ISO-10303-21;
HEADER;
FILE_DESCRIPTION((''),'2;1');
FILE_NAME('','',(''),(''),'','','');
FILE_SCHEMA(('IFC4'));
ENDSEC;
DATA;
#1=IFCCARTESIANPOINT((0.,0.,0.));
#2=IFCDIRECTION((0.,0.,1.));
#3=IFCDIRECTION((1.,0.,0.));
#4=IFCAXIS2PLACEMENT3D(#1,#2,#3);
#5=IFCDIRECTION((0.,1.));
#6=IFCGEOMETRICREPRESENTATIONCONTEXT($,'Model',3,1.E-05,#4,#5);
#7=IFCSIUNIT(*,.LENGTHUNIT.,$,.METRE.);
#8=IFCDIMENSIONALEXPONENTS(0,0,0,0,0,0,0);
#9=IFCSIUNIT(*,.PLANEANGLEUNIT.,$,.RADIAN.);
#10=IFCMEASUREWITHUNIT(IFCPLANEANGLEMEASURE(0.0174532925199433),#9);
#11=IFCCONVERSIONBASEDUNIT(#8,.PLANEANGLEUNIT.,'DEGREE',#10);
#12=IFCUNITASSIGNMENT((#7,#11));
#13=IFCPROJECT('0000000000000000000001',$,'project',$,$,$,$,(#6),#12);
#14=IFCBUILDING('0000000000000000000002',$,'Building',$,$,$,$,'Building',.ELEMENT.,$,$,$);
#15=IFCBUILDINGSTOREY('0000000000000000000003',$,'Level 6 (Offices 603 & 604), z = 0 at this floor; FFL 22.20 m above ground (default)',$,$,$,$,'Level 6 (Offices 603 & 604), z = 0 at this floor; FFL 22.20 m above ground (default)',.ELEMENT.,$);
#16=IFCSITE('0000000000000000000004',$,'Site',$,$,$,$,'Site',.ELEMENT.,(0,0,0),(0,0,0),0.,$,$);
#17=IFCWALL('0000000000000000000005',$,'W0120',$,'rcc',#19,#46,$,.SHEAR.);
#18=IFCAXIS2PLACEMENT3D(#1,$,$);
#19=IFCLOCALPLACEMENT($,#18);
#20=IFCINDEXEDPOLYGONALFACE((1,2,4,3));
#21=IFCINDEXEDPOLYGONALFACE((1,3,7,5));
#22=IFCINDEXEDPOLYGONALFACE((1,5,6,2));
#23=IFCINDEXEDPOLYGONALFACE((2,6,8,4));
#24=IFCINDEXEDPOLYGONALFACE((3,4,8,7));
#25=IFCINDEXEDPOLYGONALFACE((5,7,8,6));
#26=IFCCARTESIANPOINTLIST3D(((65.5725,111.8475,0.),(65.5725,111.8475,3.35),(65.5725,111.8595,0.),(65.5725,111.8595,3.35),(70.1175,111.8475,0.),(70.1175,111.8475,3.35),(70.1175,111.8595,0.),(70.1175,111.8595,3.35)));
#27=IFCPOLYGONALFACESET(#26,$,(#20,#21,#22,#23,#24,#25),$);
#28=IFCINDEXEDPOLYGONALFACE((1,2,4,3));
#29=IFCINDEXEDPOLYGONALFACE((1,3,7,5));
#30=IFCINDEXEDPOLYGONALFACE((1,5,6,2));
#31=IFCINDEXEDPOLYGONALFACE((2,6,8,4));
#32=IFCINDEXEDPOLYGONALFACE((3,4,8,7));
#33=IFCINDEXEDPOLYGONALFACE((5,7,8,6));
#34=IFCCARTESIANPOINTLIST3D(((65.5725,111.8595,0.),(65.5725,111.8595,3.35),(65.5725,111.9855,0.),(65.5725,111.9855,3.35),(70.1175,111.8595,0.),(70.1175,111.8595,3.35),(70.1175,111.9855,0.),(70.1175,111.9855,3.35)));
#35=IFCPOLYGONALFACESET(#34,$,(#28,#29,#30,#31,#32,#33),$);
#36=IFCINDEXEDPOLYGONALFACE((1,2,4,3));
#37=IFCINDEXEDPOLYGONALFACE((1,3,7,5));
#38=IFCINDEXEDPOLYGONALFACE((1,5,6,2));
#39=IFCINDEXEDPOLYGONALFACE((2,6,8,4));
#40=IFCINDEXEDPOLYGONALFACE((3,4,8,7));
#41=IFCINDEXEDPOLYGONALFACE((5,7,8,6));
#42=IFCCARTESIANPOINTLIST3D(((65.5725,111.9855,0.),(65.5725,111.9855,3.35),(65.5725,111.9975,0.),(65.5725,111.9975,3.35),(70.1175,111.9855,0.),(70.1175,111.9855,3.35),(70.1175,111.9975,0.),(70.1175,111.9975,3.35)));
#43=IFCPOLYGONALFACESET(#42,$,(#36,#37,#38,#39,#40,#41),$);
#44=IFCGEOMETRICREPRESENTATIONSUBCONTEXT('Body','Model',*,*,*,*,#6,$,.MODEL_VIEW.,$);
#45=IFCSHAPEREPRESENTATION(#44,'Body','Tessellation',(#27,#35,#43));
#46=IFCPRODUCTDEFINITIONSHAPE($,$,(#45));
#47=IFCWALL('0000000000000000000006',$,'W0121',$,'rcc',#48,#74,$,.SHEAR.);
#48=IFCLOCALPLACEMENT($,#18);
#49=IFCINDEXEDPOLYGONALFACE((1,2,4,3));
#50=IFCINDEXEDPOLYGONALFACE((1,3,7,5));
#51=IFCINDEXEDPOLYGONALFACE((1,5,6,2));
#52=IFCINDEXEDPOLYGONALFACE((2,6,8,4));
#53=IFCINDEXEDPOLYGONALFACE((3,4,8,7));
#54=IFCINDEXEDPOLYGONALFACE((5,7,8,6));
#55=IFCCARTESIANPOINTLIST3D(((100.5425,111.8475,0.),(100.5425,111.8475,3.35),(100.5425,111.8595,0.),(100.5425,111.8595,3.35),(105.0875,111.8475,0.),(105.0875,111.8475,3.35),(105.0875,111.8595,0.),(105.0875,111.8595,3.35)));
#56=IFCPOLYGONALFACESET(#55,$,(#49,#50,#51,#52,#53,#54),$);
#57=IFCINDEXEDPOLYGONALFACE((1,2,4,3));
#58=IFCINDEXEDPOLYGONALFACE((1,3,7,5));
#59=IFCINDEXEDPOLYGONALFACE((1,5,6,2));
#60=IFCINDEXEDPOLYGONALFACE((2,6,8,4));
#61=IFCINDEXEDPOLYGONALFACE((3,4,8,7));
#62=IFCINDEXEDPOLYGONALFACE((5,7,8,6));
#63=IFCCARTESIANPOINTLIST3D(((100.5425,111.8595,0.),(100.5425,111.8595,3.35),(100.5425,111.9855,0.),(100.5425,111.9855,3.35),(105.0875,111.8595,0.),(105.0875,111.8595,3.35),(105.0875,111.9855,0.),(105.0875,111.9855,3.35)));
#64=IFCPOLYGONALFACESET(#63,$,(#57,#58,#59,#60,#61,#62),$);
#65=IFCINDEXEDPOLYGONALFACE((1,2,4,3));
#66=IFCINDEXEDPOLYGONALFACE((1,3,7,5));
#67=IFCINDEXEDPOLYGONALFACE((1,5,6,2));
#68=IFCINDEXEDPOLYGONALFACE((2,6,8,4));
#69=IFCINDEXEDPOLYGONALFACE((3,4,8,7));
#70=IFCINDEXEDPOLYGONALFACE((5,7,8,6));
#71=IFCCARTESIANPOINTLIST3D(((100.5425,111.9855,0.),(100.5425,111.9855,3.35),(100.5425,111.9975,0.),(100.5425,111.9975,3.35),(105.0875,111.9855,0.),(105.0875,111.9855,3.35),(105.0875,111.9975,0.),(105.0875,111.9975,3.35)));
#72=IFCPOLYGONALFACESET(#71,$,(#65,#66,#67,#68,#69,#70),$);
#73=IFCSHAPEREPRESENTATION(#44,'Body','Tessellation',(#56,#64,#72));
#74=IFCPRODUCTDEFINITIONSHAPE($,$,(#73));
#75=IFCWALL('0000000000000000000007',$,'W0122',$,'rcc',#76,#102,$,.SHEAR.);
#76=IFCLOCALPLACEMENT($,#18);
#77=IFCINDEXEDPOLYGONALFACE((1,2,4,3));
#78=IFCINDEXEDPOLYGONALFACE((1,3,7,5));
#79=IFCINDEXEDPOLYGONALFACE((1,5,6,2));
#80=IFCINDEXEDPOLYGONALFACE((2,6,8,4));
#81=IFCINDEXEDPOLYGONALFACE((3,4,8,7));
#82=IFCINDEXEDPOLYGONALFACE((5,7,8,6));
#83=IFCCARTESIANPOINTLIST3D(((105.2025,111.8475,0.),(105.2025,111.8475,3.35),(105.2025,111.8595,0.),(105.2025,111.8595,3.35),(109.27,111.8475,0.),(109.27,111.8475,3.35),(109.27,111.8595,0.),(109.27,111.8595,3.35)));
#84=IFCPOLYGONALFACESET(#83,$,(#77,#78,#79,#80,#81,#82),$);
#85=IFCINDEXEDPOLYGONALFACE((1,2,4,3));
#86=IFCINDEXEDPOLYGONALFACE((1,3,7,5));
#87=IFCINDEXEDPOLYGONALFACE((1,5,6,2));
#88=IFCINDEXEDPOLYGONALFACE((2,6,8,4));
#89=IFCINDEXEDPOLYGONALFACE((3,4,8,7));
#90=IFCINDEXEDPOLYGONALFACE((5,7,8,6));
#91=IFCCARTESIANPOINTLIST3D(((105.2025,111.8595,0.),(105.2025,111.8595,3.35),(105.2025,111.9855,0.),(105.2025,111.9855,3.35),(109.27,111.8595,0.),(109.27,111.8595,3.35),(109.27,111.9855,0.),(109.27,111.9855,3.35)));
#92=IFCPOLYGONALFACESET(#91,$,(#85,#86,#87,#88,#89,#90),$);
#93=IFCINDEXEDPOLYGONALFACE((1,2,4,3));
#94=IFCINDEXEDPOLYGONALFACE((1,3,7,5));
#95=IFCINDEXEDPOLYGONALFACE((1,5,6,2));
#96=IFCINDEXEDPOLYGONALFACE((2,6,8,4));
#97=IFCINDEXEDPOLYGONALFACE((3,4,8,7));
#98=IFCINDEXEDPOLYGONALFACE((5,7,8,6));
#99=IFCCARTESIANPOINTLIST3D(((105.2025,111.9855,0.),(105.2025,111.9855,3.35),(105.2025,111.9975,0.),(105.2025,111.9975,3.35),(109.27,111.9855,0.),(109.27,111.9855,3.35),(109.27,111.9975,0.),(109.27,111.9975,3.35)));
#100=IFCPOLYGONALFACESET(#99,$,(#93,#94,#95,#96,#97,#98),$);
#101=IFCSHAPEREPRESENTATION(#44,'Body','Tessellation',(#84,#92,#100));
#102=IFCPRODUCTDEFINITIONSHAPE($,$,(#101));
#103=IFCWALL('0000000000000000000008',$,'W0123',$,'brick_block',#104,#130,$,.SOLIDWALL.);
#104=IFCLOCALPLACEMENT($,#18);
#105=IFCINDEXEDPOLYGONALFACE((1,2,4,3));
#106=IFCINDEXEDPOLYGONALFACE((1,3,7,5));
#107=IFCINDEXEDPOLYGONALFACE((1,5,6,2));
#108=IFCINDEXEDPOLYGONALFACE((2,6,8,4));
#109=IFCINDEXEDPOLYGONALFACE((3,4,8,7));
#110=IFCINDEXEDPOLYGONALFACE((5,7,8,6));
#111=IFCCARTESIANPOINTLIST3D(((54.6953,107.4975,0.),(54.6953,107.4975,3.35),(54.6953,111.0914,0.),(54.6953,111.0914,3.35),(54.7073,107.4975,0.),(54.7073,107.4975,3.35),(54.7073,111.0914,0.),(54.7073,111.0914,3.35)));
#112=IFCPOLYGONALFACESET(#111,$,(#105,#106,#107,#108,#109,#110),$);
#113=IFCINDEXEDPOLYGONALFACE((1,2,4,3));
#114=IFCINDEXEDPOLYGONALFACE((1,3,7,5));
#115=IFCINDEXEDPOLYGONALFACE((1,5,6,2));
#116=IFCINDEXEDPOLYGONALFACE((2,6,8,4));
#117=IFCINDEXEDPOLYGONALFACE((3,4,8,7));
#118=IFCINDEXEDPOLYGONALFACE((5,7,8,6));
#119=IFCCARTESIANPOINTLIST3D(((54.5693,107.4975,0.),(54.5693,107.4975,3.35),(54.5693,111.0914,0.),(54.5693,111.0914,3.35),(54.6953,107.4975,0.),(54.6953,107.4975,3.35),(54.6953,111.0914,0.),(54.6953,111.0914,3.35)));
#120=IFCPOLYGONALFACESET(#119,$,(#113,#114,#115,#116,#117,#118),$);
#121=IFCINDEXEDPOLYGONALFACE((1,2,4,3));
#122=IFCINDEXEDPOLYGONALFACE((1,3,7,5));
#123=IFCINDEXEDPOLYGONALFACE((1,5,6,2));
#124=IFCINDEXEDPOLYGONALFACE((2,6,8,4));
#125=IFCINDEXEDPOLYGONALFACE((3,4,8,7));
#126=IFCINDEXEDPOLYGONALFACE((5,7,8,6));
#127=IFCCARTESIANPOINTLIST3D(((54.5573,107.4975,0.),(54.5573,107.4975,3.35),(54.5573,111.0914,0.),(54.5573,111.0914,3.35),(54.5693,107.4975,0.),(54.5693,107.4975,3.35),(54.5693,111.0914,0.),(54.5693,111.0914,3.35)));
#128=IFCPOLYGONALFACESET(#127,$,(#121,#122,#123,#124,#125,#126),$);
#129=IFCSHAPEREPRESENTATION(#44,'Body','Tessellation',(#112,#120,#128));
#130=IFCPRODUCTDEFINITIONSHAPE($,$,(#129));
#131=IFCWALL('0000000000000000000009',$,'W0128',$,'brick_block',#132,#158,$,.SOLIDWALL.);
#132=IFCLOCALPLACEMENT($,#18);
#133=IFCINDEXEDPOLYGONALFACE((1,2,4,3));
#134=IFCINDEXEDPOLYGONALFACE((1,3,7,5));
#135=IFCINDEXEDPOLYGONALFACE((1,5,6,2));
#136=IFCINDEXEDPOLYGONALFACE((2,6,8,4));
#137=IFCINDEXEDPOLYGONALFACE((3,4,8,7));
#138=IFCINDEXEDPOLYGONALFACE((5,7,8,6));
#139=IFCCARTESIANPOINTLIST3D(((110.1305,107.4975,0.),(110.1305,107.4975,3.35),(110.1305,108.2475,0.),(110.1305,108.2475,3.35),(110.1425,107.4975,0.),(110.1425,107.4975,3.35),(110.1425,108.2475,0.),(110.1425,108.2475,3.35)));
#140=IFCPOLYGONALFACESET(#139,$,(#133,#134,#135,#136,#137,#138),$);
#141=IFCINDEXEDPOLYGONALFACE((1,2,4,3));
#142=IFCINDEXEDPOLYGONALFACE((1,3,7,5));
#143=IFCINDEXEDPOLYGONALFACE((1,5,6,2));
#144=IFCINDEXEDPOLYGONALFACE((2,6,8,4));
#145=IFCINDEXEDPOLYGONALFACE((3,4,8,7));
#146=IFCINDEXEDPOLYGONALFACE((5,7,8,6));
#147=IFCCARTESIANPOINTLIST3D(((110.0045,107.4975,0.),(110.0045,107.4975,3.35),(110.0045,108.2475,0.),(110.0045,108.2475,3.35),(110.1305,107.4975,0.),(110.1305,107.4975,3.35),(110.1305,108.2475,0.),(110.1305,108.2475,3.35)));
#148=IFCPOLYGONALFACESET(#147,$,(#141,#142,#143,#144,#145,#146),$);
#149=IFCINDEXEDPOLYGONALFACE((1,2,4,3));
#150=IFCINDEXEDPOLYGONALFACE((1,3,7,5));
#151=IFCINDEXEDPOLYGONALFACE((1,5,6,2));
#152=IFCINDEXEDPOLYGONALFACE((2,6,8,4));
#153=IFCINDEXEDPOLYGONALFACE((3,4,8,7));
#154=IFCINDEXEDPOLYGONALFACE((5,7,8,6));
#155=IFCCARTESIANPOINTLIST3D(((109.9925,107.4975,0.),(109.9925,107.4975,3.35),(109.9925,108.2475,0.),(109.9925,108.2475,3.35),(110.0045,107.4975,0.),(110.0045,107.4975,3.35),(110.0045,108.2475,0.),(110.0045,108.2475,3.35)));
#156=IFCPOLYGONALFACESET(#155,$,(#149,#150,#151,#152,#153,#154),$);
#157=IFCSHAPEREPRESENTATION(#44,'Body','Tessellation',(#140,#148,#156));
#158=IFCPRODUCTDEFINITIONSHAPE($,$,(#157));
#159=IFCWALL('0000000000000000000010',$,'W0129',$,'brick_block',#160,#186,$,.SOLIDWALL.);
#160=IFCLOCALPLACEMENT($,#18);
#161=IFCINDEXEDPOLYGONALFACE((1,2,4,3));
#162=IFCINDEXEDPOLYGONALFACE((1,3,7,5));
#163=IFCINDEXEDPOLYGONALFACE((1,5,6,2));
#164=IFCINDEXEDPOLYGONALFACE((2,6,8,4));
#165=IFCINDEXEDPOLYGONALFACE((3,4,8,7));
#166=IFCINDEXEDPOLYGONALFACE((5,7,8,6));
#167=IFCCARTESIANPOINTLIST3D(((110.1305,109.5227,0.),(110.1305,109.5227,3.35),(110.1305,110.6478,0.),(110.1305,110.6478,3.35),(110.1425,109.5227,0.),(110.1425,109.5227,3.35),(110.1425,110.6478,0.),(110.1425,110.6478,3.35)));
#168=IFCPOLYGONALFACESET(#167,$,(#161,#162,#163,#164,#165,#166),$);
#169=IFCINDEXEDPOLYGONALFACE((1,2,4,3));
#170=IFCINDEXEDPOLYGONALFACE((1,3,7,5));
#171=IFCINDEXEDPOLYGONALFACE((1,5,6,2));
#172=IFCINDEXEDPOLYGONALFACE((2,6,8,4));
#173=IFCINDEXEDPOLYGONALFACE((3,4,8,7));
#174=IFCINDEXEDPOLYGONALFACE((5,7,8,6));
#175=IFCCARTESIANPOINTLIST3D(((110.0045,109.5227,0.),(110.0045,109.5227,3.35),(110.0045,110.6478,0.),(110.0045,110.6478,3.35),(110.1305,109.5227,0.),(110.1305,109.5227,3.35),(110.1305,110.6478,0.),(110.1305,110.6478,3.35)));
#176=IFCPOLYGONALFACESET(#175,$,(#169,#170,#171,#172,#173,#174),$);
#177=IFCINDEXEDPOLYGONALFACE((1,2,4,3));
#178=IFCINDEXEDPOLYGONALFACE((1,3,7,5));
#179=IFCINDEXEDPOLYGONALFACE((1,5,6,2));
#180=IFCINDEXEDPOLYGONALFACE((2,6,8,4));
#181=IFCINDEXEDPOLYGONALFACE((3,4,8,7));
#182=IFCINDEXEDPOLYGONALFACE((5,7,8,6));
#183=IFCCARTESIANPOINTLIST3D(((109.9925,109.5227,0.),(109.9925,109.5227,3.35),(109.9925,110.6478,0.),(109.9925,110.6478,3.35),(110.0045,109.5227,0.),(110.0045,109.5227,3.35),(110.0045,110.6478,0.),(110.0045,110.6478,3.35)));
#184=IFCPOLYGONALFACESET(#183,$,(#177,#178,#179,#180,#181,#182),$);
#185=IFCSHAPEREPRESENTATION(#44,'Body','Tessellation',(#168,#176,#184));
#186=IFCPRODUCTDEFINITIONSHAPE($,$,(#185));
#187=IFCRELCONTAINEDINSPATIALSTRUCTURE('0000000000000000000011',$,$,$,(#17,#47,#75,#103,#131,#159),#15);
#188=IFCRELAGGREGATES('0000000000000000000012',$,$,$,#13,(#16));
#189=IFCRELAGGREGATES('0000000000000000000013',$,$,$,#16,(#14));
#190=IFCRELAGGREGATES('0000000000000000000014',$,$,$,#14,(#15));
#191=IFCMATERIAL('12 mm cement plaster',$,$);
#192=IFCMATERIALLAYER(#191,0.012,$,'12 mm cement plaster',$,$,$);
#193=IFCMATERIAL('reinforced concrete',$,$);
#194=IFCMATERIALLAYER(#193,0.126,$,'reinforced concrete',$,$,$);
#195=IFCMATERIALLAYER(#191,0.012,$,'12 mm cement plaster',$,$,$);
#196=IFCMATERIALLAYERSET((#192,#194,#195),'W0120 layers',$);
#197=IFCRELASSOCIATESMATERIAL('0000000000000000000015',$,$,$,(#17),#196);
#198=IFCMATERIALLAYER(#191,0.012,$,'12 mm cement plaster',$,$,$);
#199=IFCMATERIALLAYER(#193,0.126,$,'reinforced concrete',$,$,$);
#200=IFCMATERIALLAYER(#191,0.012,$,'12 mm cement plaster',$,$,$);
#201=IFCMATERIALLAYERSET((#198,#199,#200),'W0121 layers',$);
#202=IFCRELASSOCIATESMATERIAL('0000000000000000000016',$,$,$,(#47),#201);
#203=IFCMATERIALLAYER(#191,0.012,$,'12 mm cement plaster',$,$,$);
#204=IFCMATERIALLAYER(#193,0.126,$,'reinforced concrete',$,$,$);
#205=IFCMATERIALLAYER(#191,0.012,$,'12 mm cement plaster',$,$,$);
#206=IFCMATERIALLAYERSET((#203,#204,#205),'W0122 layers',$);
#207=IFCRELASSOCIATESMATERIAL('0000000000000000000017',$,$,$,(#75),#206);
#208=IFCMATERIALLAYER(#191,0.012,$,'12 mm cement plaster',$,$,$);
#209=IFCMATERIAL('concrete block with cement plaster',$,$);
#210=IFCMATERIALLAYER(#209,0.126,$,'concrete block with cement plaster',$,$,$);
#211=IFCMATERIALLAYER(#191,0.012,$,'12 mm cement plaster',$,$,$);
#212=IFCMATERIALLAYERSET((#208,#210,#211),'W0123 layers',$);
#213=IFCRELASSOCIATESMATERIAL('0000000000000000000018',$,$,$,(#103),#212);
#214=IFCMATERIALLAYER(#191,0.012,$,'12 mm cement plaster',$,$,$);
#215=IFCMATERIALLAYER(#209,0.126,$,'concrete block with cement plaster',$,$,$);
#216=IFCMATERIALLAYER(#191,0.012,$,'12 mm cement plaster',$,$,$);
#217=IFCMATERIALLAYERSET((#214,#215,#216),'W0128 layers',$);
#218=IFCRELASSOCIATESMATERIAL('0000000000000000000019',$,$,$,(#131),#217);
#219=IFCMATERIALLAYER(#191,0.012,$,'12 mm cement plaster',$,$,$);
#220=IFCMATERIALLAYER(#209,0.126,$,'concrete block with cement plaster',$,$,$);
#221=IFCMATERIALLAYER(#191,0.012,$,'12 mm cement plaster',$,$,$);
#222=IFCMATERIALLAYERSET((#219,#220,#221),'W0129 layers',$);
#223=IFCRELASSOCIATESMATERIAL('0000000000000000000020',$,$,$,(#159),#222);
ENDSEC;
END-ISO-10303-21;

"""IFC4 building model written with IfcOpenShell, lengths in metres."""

from ifc_helpers import new_model, entity, si_unit, converted_unit, direction, frame, frame_2d, origin_with_axes, origin_2d_with_axis, place, context, subcontext, project, spatial, rectangle, extrude, material, layer, layer_set, layer_usage, element, save


model = new_model("IFC4")

# Units and contexts
model_context = context("Model", 3, precision=1e-05, world=origin_with_axes(), true_north=direction((0.0, 1.0)))
body_context = subcontext(model_context, "Body", "Model", "MODEL_VIEW")
ifc_project = project(units=[si_unit("LENGTHUNIT", "METRE"), converted_unit("PLANEANGLEUNIT", "DEGREE", entity("IfcPlaneAngleMeasure", 0.0174532925199433), si_unit("PLANEANGLEUNIT", "RADIAN"), dimensions=[0, 0, 0, 0, 0, 0, 0])], contexts=[model_context])

# Site, building, storey
site = spatial("IfcSite", under=ifc_project, Name="Site", LongName="Site", CompositionType="ELEMENT", RefLatitude=(0, 0, 0), RefLongitude=(0, 0, 0), RefElevation=0.0)
building = spatial("IfcBuilding", under=site, Name="Building", LongName="Building", CompositionType="ELEMENT")
storey = spatial("IfcBuildingStorey", under=building, Name="Level 6 (Offices 603 & 604), z = 0 at this floor; FFL 22.20 m above ground (default)", LongName="Level 6 (Offices 603 & 604), z = 0 at this floor; FFL 22.20 m above ground (default)", CompositionType="ELEMENT")

# Walls
ifc_material_1 = material(Name="12 mm cement plaster")
ifc_material_2 = material(Name="concrete block with cement plaster")
placement = place(None, origin_with_axes())
ifc_material_3 = material(Name="reinforced concrete")
ifc_layer_1 = layer(ifc_material_1, 0.012, Name="12 mm cement plaster")
ifc_layer_2 = layer(ifc_material_3, 0.126, Name="reinforced concrete")
ifc_layer_3 = layer(ifc_material_1, 0.012, Name="12 mm cement plaster")
ifc_layer_set_1 = layer_set([ifc_layer_1, ifc_layer_2, ifc_layer_3], Name="W0120 layers")
ifc_layer_usage_1 = layer_usage(ifc_layer_set_1, "AXIS2", "POSITIVE", -0.075)
element("IfcWall", 1, at=placement, inside=storey, material=ifc_layer_usage_1, Name="W0120", ObjectType="rcc", PredefinedType="SHEAR", context=body_context, shape_type="SweptSolid", body=[
    extrude(rectangle(XDim=4.545, YDim=0.012, at=origin_2d_with_axis()), frame((67.845, 111.8535, 0.0), z_axis=(0.0, 0.0, 1.0), x_axis=(1.0, 0.0, 0.0)), (0.0, 0.0, 1.0), 3.35),
    extrude(rectangle(XDim=4.545, YDim=0.126, at=frame_2d((0.0, 0.069), x_axis=(1.0, 0.0))), frame((67.845, 111.8535, 0.0), z_axis=(0.0, 0.0, 1.0), x_axis=(1.0, 0.0, 0.0)), (0.0, 0.0, 1.0), 3.35),
    extrude(rectangle(XDim=4.545, YDim=0.012, at=frame_2d((0.0, 0.138), x_axis=(1.0, 0.0))), frame((67.845, 111.8535, 0.0), z_axis=(0.0, 0.0, 1.0), x_axis=(1.0, 0.0, 0.0)), (0.0, 0.0, 1.0), 3.35),
])
ifc_layer_4 = layer(ifc_material_1, 0.012, Name="12 mm cement plaster")
ifc_layer_5 = layer(ifc_material_3, 0.126, Name="reinforced concrete")
ifc_layer_6 = layer(ifc_material_1, 0.012, Name="12 mm cement plaster")
ifc_layer_set_2 = layer_set([ifc_layer_4, ifc_layer_5, ifc_layer_6], Name="W0121 layers")
ifc_layer_usage_2 = layer_usage(ifc_layer_set_2, "AXIS2", "POSITIVE", -0.075)
element("IfcWall", 2, at=placement, inside=storey, material=ifc_layer_usage_2, Name="W0121", ObjectType="rcc", PredefinedType="SHEAR", context=body_context, shape_type="SweptSolid", body=[
    extrude(rectangle(XDim=4.545, YDim=0.012, at=origin_2d_with_axis()), frame((102.815, 111.8535, 0.0), z_axis=(0.0, 0.0, 1.0), x_axis=(1.0, 0.0, 0.0)), (0.0, 0.0, 1.0), 3.35),
    extrude(rectangle(XDim=4.545, YDim=0.126, at=frame_2d((0.0, 0.069), x_axis=(1.0, 0.0))), frame((102.815, 111.8535, 0.0), z_axis=(0.0, 0.0, 1.0), x_axis=(1.0, 0.0, 0.0)), (0.0, 0.0, 1.0), 3.35),
    extrude(rectangle(XDim=4.545, YDim=0.012, at=frame_2d((0.0, 0.138), x_axis=(1.0, 0.0))), frame((102.815, 111.8535, 0.0), z_axis=(0.0, 0.0, 1.0), x_axis=(1.0, 0.0, 0.0)), (0.0, 0.0, 1.0), 3.35),
])
ifc_layer_7 = layer(ifc_material_1, 0.012, Name="12 mm cement plaster")
ifc_layer_8 = layer(ifc_material_3, 0.126, Name="reinforced concrete")
ifc_layer_9 = layer(ifc_material_1, 0.012, Name="12 mm cement plaster")
ifc_layer_set_3 = layer_set([ifc_layer_7, ifc_layer_8, ifc_layer_9], Name="W0122 layers")
ifc_layer_usage_3 = layer_usage(ifc_layer_set_3, "AXIS2", "POSITIVE", -0.075)
element("IfcWall", 3, at=placement, inside=storey, material=ifc_layer_usage_3, Name="W0122", ObjectType="rcc", PredefinedType="SHEAR", context=body_context, shape_type="SweptSolid", body=[
    extrude(rectangle(XDim=4.0675, YDim=0.012, at=frame_2d((0.0, 0.0), x_axis=(1.0, 0.0))), frame((107.2362, 111.8535, 0.0), z_axis=(0.0, 0.0, 1.0), x_axis=(1.0, 0.0, 0.0)), (0.0, 0.0, 1.0), 3.35),
    extrude(rectangle(XDim=4.0675, YDim=0.126, at=frame_2d((0.0, 0.069), x_axis=(1.0, 0.0))), frame((107.2362, 111.8535, 0.0), z_axis=(0.0, 0.0, 1.0), x_axis=(1.0, 0.0, 0.0)), (0.0, 0.0, 1.0), 3.35),
    extrude(rectangle(XDim=4.0675, YDim=0.012, at=frame_2d((0.0, 0.138), x_axis=(1.0, 0.0))), frame((107.2362, 111.8535, 0.0), z_axis=(0.0, 0.0, 1.0), x_axis=(1.0, 0.0, 0.0)), (0.0, 0.0, 1.0), 3.35),
])
ifc_layer_10 = layer(ifc_material_1, 0.012, Name="12 mm cement plaster")
ifc_layer_11 = layer(ifc_material_2, 0.126, Name="concrete block with cement plaster")
ifc_layer_12 = layer(ifc_material_1, 0.012, Name="12 mm cement plaster")
ifc_layer_set_4 = layer_set([ifc_layer_10, ifc_layer_11, ifc_layer_12], Name="W0123 layers")
ifc_layer_usage_4 = layer_usage(ifc_layer_set_4, "AXIS2", "POSITIVE", -0.075)
element("IfcWall", 4, at=placement, inside=storey, material=ifc_layer_usage_4, Name="W0123", ObjectType="brick_block", PredefinedType="SOLIDWALL", context=body_context, shape_type="SweptSolid", body=[
    extrude(rectangle(XDim=3.5939, YDim=0.012, at=frame_2d((0.0, 0.0), x_axis=(0.0, 1.0))), frame((54.7013, 109.2944, 0.0), z_axis=(0.0, 0.0, 1.0), x_axis=(1.0, 0.0, 0.0)), (0.0, 0.0, 1.0), 3.35),
    extrude(rectangle(XDim=3.5939, YDim=0.126, at=frame_2d((-0.069, 0.0), x_axis=(0.0, 1.0))), frame((54.7013, 109.2944, 0.0), z_axis=(0.0, 0.0, 1.0), x_axis=(1.0, 0.0, 0.0)), (0.0, 0.0, 1.0), 3.35),
    extrude(rectangle(XDim=3.5939, YDim=0.012, at=frame_2d((-0.138, 0.0), x_axis=(0.0, 1.0))), frame((54.7013, 109.2944, 0.0), z_axis=(0.0, 0.0, 1.0), x_axis=(1.0, 0.0, 0.0)), (0.0, 0.0, 1.0), 3.35),
])
ifc_layer_13 = layer(ifc_material_1, 0.012, Name="12 mm cement plaster")
ifc_layer_14 = layer(ifc_material_2, 0.126, Name="concrete block with cement plaster")
ifc_layer_15 = layer(ifc_material_1, 0.012, Name="12 mm cement plaster")
ifc_layer_set_5 = layer_set([ifc_layer_13, ifc_layer_14, ifc_layer_15], Name="W0128 layers")
ifc_layer_usage_5 = layer_usage(ifc_layer_set_5, "AXIS2", "POSITIVE", -0.075)
element("IfcWall", 5, at=placement, inside=storey, material=ifc_layer_usage_5, Name="W0128", ObjectType="brick_block", PredefinedType="SOLIDWALL", context=body_context, shape_type="SweptSolid", body=[
    extrude(rectangle(XDim=0.75, YDim=0.012, at=frame_2d((0.0, 0.0), x_axis=(0.0, 1.0))), frame((110.1365, 107.8725, 0.0), z_axis=(0.0, 0.0, 1.0), x_axis=(1.0, 0.0, 0.0)), (0.0, 0.0, 1.0), 3.35),
    extrude(rectangle(XDim=0.75, YDim=0.126, at=frame_2d((-0.069, 0.0), x_axis=(0.0, 1.0))), frame((110.1365, 107.8725, 0.0), z_axis=(0.0, 0.0, 1.0), x_axis=(1.0, 0.0, 0.0)), (0.0, 0.0, 1.0), 3.35),
    extrude(rectangle(XDim=0.75, YDim=0.012, at=frame_2d((-0.138, 0.0), x_axis=(0.0, 1.0))), frame((110.1365, 107.8725, 0.0), z_axis=(0.0, 0.0, 1.0), x_axis=(1.0, 0.0, 0.0)), (0.0, 0.0, 1.0), 3.35),
])
ifc_layer_16 = layer(ifc_material_1, 0.012, Name="12 mm cement plaster")
ifc_layer_17 = layer(ifc_material_2, 0.126, Name="concrete block with cement plaster")
ifc_layer_18 = layer(ifc_material_1, 0.012, Name="12 mm cement plaster")
ifc_layer_set_6 = layer_set([ifc_layer_16, ifc_layer_17, ifc_layer_18], Name="W0129 layers")
ifc_layer_usage_6 = layer_usage(ifc_layer_set_6, "AXIS2", "POSITIVE", -0.075)
element("IfcWall", 6, at=placement, inside=storey, material=ifc_layer_usage_6, Name="W0129", ObjectType="brick_block", PredefinedType="SOLIDWALL", context=body_context, shape_type="SweptSolid", body=[
    extrude(rectangle(XDim=1.1251, YDim=0.012, at=frame_2d((0.0, 0.0), x_axis=(0.0, 1.0))), frame((110.1365, 110.0853, 0.0), z_axis=(0.0, 0.0, 1.0), x_axis=(1.0, 0.0, 0.0)), (0.0, 0.0, 1.0), 3.35),
    extrude(rectangle(XDim=1.1251, YDim=0.126, at=frame_2d((-0.069, 0.0), x_axis=(0.0, 1.0))), frame((110.1365, 110.0853, 0.0), z_axis=(0.0, 0.0, 1.0), x_axis=(1.0, 0.0, 0.0)), (0.0, 0.0, 1.0), 3.35),
    extrude(rectangle(XDim=1.1251, YDim=0.012, at=frame_2d((-0.138, 0.0), x_axis=(0.0, 1.0))), frame((110.1365, 110.0853, 0.0), z_axis=(0.0, 0.0, 1.0), x_axis=(1.0, 0.0, 0.0)), (0.0, 0.0, 1.0), 3.35),
])

save(model, "model.ifc")
